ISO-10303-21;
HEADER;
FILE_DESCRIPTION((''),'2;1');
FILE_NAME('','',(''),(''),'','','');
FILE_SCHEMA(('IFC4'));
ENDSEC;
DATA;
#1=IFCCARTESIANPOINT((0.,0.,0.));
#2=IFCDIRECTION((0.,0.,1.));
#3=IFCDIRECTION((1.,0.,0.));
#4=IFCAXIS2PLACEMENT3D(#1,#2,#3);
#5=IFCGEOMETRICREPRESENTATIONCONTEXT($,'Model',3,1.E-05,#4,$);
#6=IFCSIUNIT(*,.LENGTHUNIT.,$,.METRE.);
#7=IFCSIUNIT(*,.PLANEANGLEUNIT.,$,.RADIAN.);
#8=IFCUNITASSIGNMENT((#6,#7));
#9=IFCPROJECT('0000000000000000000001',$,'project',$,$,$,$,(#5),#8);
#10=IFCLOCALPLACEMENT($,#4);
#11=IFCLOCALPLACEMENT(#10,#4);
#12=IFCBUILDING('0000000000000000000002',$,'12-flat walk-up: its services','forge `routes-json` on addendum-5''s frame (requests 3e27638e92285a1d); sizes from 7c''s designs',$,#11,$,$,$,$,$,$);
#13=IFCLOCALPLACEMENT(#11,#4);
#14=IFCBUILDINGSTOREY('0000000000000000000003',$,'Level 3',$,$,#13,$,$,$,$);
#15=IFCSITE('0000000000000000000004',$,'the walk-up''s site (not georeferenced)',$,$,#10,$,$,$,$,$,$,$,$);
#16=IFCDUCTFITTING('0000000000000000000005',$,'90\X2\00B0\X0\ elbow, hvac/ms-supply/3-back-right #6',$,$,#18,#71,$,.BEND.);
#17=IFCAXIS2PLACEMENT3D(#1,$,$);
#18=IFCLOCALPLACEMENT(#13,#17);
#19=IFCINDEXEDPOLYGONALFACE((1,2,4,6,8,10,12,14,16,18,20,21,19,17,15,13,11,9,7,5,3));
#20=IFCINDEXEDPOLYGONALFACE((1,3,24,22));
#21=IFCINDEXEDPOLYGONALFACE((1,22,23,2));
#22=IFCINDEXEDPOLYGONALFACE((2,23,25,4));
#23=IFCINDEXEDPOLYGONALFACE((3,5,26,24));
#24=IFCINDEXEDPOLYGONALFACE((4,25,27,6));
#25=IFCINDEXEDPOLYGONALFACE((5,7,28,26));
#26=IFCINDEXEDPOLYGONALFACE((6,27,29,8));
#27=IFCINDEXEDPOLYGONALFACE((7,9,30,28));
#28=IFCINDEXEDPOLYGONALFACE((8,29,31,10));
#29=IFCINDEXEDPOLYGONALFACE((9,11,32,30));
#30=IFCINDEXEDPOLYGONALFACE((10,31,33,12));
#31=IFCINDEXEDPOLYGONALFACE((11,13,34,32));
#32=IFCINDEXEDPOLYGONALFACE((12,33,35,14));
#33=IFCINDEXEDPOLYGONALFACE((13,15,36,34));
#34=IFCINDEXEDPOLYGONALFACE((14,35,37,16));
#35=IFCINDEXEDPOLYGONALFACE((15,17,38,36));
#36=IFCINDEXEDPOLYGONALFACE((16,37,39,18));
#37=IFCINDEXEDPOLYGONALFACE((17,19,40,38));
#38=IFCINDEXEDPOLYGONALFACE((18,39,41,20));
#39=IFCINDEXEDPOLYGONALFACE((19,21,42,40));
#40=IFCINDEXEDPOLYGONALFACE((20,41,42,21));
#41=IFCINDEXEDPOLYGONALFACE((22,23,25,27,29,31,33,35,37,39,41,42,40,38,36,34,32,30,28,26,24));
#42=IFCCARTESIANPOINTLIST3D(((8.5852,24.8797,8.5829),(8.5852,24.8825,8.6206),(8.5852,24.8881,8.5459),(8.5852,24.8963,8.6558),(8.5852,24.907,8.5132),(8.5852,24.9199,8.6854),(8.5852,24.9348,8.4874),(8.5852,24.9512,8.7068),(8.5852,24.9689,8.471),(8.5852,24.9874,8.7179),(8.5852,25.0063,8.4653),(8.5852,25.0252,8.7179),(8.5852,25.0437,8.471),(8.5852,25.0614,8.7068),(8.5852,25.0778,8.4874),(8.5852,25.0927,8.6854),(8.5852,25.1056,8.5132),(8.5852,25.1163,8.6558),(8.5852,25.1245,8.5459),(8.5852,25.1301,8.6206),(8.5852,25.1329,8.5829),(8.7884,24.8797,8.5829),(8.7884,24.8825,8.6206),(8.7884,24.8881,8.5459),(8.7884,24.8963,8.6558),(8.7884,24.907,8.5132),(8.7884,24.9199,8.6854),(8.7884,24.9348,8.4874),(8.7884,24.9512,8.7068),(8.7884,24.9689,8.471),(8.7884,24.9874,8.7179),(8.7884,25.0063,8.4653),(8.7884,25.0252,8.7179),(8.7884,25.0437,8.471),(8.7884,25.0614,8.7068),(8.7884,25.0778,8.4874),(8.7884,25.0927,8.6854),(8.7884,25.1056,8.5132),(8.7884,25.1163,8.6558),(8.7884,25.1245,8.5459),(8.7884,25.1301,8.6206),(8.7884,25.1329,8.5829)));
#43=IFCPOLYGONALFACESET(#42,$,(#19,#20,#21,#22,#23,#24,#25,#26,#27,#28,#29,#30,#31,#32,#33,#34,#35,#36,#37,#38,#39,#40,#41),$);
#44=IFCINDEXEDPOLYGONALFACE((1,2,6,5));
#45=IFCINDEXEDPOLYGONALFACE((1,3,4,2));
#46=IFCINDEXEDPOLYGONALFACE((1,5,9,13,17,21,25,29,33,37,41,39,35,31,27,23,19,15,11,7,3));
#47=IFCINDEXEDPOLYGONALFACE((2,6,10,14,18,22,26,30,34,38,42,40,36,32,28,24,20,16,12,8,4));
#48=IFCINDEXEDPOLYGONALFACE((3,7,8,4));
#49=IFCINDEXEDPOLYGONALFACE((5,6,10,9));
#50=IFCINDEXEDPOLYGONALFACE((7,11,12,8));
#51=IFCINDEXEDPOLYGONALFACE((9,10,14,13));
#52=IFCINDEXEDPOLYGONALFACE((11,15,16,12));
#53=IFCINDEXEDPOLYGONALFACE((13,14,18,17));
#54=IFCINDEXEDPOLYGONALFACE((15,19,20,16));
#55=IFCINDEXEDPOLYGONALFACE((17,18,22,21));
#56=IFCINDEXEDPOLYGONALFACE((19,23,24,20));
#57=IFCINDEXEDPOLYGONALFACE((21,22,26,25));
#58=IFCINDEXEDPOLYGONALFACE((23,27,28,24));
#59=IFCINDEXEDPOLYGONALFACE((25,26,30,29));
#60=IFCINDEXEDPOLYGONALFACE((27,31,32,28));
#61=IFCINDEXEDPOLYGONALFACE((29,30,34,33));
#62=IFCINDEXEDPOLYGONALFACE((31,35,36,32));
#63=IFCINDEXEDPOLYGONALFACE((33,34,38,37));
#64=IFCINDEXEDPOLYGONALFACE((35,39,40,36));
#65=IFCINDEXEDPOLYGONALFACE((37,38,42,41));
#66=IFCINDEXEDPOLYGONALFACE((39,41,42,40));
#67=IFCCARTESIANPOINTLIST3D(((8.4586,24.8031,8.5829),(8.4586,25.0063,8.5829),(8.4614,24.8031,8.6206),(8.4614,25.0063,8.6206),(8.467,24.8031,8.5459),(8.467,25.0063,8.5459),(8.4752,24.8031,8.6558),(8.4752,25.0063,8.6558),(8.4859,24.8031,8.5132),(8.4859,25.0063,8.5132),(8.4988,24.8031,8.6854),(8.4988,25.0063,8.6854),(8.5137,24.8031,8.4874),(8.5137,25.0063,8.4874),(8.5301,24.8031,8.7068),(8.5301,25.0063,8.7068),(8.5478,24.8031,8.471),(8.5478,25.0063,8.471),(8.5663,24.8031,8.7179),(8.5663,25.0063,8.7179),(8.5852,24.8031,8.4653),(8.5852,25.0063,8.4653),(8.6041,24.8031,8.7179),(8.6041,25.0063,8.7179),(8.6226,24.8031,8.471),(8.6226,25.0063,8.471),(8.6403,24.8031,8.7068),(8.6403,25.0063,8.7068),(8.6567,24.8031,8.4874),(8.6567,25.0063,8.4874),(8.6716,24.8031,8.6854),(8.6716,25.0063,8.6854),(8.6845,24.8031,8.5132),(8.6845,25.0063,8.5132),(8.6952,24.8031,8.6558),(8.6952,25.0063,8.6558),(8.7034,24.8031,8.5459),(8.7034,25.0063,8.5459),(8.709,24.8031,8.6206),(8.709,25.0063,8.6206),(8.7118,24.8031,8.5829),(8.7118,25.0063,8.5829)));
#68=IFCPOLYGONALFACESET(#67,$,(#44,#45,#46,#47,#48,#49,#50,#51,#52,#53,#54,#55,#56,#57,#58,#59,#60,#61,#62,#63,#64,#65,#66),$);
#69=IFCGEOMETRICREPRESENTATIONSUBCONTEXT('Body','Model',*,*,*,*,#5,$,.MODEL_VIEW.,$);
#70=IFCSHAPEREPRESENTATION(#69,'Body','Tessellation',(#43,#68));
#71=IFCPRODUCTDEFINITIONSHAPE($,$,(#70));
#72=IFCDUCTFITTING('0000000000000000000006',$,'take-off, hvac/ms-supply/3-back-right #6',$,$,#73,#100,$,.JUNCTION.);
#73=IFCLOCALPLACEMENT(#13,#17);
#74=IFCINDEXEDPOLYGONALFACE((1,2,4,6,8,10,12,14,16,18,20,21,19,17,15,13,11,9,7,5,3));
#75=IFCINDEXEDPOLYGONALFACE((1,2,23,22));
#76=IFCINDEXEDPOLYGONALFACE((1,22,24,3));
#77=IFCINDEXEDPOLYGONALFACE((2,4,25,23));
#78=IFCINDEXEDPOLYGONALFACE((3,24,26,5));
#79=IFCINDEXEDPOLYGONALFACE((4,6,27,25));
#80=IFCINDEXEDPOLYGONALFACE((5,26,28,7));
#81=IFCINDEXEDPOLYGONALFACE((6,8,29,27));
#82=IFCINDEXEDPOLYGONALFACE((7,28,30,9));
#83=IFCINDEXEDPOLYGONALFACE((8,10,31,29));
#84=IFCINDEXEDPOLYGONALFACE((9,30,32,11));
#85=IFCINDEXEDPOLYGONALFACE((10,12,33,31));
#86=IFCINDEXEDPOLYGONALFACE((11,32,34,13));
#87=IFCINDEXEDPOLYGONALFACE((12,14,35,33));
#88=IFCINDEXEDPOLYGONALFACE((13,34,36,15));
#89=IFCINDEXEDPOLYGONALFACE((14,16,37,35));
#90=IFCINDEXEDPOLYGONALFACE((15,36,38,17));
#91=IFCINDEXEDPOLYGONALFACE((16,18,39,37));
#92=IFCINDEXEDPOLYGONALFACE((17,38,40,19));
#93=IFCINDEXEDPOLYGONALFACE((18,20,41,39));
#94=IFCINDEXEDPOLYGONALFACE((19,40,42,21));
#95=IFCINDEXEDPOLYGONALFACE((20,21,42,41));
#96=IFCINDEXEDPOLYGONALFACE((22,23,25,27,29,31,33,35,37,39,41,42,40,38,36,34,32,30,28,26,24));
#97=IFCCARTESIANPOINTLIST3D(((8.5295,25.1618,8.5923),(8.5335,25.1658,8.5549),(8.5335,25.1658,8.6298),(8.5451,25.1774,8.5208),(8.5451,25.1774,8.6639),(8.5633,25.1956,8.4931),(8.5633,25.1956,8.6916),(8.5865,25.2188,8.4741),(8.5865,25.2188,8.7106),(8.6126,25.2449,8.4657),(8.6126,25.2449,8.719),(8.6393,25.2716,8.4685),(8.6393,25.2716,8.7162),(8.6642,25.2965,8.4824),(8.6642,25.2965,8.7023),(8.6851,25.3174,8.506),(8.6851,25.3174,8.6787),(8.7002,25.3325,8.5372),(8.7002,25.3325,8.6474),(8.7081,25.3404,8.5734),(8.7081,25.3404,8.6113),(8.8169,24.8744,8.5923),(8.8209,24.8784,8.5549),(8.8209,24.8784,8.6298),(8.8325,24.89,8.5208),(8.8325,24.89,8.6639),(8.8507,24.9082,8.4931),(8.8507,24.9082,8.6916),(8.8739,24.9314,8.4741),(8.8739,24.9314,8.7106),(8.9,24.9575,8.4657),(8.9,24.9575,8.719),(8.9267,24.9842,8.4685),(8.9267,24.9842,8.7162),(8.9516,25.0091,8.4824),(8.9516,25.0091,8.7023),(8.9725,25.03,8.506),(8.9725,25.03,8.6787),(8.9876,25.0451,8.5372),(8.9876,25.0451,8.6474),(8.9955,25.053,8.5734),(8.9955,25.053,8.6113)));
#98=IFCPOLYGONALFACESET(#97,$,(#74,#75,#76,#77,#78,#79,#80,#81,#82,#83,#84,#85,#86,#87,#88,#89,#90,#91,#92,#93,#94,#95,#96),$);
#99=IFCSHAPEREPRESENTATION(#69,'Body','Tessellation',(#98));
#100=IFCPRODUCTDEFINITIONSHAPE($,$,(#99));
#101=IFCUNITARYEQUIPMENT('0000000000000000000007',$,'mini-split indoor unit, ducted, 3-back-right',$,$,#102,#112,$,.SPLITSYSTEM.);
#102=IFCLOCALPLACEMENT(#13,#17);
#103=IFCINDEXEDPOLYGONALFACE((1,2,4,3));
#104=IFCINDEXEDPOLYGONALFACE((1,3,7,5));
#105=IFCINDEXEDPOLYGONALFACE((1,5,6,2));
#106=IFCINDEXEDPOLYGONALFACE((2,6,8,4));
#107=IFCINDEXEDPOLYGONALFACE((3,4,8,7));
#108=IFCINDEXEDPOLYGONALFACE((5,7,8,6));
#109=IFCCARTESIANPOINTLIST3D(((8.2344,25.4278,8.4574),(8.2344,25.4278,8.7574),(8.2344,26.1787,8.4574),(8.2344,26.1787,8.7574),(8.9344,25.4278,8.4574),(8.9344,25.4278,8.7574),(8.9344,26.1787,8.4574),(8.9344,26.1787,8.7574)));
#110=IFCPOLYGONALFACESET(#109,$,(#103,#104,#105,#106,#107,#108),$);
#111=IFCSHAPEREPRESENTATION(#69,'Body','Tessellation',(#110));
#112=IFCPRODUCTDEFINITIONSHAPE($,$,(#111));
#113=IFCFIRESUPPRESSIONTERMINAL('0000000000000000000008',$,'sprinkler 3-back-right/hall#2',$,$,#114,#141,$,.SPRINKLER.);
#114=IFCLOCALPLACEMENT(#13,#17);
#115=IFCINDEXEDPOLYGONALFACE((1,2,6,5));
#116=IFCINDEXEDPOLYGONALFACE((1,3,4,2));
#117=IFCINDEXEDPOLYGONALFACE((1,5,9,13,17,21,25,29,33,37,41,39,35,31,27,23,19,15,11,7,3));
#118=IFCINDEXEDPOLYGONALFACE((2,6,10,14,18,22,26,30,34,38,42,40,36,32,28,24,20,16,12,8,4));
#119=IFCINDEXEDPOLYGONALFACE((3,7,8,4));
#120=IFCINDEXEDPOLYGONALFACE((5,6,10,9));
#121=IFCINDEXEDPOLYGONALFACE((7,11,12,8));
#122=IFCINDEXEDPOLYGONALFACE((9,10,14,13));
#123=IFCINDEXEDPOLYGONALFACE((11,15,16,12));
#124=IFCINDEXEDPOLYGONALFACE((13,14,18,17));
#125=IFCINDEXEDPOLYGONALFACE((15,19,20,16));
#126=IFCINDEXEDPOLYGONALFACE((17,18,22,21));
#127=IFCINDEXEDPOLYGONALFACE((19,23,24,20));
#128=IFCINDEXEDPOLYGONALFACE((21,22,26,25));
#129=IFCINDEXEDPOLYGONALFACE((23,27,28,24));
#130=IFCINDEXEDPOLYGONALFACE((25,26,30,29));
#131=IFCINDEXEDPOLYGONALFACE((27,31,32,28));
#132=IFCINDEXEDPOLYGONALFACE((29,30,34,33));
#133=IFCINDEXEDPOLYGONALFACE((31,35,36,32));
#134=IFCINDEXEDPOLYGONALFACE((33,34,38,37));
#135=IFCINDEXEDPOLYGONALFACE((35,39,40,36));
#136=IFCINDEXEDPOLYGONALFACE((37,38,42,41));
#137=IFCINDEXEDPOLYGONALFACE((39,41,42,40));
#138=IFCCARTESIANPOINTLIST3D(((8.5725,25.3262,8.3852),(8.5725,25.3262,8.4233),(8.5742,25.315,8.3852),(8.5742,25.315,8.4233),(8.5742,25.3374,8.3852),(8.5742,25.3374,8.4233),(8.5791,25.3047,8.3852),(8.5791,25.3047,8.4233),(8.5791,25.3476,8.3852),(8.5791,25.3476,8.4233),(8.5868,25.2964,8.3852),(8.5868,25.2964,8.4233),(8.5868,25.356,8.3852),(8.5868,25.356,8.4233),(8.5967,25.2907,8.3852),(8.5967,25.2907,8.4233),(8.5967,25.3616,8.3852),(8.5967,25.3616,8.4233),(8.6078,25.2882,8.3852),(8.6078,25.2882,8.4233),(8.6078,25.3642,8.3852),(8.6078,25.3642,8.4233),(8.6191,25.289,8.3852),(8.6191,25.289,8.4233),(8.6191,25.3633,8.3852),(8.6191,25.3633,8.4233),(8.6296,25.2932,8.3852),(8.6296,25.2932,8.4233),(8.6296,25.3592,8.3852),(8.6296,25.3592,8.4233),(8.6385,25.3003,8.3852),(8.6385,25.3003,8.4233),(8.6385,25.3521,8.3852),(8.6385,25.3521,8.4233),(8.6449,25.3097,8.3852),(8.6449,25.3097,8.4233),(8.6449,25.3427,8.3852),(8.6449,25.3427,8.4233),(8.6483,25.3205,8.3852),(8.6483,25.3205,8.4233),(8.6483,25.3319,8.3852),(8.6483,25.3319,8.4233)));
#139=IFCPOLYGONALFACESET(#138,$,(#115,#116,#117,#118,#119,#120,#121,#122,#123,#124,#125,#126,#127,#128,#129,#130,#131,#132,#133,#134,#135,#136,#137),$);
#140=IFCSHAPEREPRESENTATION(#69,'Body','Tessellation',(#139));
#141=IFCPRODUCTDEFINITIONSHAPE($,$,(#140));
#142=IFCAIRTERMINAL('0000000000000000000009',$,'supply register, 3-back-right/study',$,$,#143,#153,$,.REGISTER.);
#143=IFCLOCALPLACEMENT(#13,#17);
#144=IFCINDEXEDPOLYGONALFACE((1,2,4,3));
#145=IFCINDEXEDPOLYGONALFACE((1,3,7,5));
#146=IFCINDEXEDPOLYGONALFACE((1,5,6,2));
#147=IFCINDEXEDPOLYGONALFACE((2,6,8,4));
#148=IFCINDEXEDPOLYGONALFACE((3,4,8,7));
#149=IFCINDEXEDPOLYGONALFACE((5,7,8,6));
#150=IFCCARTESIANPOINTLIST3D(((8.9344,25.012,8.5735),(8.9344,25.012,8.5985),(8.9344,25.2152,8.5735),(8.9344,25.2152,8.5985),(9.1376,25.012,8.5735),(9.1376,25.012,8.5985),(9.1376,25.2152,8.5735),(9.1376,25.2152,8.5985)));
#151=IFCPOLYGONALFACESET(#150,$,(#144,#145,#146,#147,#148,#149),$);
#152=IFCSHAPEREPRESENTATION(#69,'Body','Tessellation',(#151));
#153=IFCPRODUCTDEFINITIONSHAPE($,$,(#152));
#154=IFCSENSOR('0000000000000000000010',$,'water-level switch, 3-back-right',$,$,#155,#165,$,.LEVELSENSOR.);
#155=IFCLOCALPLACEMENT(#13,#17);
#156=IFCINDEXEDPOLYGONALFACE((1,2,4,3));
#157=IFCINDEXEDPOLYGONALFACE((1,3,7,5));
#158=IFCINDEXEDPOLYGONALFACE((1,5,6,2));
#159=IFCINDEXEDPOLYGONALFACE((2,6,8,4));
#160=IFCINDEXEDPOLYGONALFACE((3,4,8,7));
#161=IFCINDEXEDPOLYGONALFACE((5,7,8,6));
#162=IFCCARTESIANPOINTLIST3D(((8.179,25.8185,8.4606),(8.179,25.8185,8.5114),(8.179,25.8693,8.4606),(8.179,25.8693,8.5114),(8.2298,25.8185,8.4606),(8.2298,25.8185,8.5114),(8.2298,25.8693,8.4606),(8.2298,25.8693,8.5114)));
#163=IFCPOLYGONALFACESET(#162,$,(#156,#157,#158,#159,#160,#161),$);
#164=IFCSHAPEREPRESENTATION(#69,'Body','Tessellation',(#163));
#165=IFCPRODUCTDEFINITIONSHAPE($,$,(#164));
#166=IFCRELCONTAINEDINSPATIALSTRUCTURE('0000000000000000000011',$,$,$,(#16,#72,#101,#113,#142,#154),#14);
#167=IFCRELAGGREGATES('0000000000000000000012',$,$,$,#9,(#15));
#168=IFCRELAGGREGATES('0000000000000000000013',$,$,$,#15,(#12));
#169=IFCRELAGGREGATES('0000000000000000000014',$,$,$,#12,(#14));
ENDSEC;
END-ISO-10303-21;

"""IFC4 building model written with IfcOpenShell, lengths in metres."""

from ifc_helpers import new_model, entity, si_unit, frame, frame_2d, origin, origin_with_axes, place, context, subcontext, project, spatial, rectangle, extrude, element, save


model = new_model("IFC4")

# Units and contexts
model_context = context("Model", 3, precision=1e-05, world=origin_with_axes())
body_context = subcontext(model_context, "Body", "Model", "MODEL_VIEW")
ifc_project = project(units=[si_unit("LENGTHUNIT", "METRE"), si_unit("PLANEANGLEUNIT", "RADIAN")], contexts=[model_context])

# Site, building, storey
site_placement = place(None, origin_with_axes())
site = spatial("IfcSite", under=ifc_project, at=site_placement, Name="the walk-up's site (not georeferenced)")
building_placement = place(site_placement, origin_with_axes())
building = spatial("IfcBuilding", under=site, at=building_placement, Name="12-flat walk-up: its services", Description="forge `routes-json` on addendum-5's frame (requests 3e27638e92285a1d); sizes from 7c's designs")
storey_placement = place(building_placement, origin_with_axes())
storey = spatial("IfcBuildingStorey", under=building, at=storey_placement, Name="Level 3")

# Duct fittings
duct_fitting_1_placement = place(storey_placement, frame((8.7884, 25.0063, 8.5923), z_axis=(0.0, 0.0, 1.0), x_axis=(1.0, 0.0, 0.0)))
element("IfcDuctFitting", 1, at=duct_fitting_1_placement, inside=storey, Name="90° elbow, hvac/ms-supply/3-back-right #6", PredefinedType="BEND", context=body_context, shape_type="AdvancedSweptSolid", body=[
    entity("IfcSweptDiskSolid", entity("IfcPolyline", [entity("IfcCartesianPoint", [0.0, 0.0, 0.0]), entity("IfcCartesianPoint", [-0.2032, 0.0, 0.0])]), 0.127),
    entity("IfcSweptDiskSolid", entity("IfcPolyline", [entity("IfcCartesianPoint", [-0.2032, 0.0, 0.0]), entity("IfcCartesianPoint", [-0.2032, -0.2032, 0.0])]), 0.127),
])
duct_fitting_2_placement = place(storey_placement, frame((8.6193, 25.2516, 8.5923), z_axis=(0.0, 0.0, 1.0), x_axis=(1.0, 0.0, 0.0)))
element("IfcDuctFitting", 2, at=duct_fitting_2_placement, inside=storey, Name="take-off, hvac/ms-supply/3-back-right #6", PredefinedType="JUNCTION", context=body_context, shape_type="AdvancedSweptSolid", body=[
    entity("IfcSweptDiskSolid", entity("IfcPolyline", [entity("IfcCartesianPoint", [0.0, 0.0, 0.0]), entity("IfcCartesianPoint", [0.2874, -0.2874, 0.0])]), 0.127),
])

# Unitary equipment
unitary_equipment_placement = place(storey_placement, frame((8.2344, 25.4278, 8.4574), z_axis=(0.0, 0.0, 1.0), x_axis=(1.0, 0.0, 0.0)))
element("IfcUnitaryEquipment", 3, at=unitary_equipment_placement, inside=storey, Name="mini-split indoor unit, ducted, 3-back-right", PredefinedType="SPLITSYSTEM", context=body_context, shape_type="SweptSolid", body=[
    extrude(rectangle(XDim=0.7001, YDim=0.7509, at=frame_2d((0.35, 0.3754))), origin(), (0.0, 0.0, 1.0), 0.3),
])

# Fire suppression terminal
fire_suppression_terminal_placement = place(storey_placement, frame((8.6106, 25.3262, 8.4233), z_axis=(0.0, 0.0, 1.0), x_axis=(1.0, 0.0, 0.0)))
element("IfcFireSuppressionTerminal", 4, at=fire_suppression_terminal_placement, inside=storey, Name="sprinkler 3-back-right/hall#2", PredefinedType="SPRINKLER", context=body_context, shape_type="AdvancedSweptSolid", body=[
    entity("IfcSweptDiskSolid", entity("IfcPolyline", [entity("IfcCartesianPoint", [0.0, 0.0, 0.0]), entity("IfcCartesianPoint", [0.0, 0.0, -0.0381])]), 0.0381),
])

# Air terminal
air_terminal_placement = place(storey_placement, frame((8.9345, 25.012, 8.5735), z_axis=(0.0, 0.0, 1.0), x_axis=(1.0, 0.0, 0.0)))
element("IfcAirTerminal", 5, at=air_terminal_placement, inside=storey, Name="supply register, 3-back-right/study", PredefinedType="REGISTER", context=body_context, shape_type="SweptSolid", body=[
    extrude(rectangle(XDim=0.2032, YDim=0.2032, at=frame_2d((0.1016, 0.1016))), origin(), (0.0, 0.0, 1.0), 0.025),
])

# Sensor
sensor_placement = place(storey_placement, frame((8.179, 25.8185, 8.4606), z_axis=(0.0, 0.0, 1.0), x_axis=(1.0, 0.0, 0.0)))
element("IfcSensor", 6, at=sensor_placement, inside=storey, Name="water-level switch, 3-back-right", PredefinedType="LEVELSENSOR", context=body_context, shape_type="SweptSolid", body=[
    extrude(rectangle(XDim=0.0508, YDim=0.0508, at=frame_2d((0.0254, 0.0254))), origin(), (0.0, 0.0, 1.0), 0.0508),
])

save(model, "model.ifc")
